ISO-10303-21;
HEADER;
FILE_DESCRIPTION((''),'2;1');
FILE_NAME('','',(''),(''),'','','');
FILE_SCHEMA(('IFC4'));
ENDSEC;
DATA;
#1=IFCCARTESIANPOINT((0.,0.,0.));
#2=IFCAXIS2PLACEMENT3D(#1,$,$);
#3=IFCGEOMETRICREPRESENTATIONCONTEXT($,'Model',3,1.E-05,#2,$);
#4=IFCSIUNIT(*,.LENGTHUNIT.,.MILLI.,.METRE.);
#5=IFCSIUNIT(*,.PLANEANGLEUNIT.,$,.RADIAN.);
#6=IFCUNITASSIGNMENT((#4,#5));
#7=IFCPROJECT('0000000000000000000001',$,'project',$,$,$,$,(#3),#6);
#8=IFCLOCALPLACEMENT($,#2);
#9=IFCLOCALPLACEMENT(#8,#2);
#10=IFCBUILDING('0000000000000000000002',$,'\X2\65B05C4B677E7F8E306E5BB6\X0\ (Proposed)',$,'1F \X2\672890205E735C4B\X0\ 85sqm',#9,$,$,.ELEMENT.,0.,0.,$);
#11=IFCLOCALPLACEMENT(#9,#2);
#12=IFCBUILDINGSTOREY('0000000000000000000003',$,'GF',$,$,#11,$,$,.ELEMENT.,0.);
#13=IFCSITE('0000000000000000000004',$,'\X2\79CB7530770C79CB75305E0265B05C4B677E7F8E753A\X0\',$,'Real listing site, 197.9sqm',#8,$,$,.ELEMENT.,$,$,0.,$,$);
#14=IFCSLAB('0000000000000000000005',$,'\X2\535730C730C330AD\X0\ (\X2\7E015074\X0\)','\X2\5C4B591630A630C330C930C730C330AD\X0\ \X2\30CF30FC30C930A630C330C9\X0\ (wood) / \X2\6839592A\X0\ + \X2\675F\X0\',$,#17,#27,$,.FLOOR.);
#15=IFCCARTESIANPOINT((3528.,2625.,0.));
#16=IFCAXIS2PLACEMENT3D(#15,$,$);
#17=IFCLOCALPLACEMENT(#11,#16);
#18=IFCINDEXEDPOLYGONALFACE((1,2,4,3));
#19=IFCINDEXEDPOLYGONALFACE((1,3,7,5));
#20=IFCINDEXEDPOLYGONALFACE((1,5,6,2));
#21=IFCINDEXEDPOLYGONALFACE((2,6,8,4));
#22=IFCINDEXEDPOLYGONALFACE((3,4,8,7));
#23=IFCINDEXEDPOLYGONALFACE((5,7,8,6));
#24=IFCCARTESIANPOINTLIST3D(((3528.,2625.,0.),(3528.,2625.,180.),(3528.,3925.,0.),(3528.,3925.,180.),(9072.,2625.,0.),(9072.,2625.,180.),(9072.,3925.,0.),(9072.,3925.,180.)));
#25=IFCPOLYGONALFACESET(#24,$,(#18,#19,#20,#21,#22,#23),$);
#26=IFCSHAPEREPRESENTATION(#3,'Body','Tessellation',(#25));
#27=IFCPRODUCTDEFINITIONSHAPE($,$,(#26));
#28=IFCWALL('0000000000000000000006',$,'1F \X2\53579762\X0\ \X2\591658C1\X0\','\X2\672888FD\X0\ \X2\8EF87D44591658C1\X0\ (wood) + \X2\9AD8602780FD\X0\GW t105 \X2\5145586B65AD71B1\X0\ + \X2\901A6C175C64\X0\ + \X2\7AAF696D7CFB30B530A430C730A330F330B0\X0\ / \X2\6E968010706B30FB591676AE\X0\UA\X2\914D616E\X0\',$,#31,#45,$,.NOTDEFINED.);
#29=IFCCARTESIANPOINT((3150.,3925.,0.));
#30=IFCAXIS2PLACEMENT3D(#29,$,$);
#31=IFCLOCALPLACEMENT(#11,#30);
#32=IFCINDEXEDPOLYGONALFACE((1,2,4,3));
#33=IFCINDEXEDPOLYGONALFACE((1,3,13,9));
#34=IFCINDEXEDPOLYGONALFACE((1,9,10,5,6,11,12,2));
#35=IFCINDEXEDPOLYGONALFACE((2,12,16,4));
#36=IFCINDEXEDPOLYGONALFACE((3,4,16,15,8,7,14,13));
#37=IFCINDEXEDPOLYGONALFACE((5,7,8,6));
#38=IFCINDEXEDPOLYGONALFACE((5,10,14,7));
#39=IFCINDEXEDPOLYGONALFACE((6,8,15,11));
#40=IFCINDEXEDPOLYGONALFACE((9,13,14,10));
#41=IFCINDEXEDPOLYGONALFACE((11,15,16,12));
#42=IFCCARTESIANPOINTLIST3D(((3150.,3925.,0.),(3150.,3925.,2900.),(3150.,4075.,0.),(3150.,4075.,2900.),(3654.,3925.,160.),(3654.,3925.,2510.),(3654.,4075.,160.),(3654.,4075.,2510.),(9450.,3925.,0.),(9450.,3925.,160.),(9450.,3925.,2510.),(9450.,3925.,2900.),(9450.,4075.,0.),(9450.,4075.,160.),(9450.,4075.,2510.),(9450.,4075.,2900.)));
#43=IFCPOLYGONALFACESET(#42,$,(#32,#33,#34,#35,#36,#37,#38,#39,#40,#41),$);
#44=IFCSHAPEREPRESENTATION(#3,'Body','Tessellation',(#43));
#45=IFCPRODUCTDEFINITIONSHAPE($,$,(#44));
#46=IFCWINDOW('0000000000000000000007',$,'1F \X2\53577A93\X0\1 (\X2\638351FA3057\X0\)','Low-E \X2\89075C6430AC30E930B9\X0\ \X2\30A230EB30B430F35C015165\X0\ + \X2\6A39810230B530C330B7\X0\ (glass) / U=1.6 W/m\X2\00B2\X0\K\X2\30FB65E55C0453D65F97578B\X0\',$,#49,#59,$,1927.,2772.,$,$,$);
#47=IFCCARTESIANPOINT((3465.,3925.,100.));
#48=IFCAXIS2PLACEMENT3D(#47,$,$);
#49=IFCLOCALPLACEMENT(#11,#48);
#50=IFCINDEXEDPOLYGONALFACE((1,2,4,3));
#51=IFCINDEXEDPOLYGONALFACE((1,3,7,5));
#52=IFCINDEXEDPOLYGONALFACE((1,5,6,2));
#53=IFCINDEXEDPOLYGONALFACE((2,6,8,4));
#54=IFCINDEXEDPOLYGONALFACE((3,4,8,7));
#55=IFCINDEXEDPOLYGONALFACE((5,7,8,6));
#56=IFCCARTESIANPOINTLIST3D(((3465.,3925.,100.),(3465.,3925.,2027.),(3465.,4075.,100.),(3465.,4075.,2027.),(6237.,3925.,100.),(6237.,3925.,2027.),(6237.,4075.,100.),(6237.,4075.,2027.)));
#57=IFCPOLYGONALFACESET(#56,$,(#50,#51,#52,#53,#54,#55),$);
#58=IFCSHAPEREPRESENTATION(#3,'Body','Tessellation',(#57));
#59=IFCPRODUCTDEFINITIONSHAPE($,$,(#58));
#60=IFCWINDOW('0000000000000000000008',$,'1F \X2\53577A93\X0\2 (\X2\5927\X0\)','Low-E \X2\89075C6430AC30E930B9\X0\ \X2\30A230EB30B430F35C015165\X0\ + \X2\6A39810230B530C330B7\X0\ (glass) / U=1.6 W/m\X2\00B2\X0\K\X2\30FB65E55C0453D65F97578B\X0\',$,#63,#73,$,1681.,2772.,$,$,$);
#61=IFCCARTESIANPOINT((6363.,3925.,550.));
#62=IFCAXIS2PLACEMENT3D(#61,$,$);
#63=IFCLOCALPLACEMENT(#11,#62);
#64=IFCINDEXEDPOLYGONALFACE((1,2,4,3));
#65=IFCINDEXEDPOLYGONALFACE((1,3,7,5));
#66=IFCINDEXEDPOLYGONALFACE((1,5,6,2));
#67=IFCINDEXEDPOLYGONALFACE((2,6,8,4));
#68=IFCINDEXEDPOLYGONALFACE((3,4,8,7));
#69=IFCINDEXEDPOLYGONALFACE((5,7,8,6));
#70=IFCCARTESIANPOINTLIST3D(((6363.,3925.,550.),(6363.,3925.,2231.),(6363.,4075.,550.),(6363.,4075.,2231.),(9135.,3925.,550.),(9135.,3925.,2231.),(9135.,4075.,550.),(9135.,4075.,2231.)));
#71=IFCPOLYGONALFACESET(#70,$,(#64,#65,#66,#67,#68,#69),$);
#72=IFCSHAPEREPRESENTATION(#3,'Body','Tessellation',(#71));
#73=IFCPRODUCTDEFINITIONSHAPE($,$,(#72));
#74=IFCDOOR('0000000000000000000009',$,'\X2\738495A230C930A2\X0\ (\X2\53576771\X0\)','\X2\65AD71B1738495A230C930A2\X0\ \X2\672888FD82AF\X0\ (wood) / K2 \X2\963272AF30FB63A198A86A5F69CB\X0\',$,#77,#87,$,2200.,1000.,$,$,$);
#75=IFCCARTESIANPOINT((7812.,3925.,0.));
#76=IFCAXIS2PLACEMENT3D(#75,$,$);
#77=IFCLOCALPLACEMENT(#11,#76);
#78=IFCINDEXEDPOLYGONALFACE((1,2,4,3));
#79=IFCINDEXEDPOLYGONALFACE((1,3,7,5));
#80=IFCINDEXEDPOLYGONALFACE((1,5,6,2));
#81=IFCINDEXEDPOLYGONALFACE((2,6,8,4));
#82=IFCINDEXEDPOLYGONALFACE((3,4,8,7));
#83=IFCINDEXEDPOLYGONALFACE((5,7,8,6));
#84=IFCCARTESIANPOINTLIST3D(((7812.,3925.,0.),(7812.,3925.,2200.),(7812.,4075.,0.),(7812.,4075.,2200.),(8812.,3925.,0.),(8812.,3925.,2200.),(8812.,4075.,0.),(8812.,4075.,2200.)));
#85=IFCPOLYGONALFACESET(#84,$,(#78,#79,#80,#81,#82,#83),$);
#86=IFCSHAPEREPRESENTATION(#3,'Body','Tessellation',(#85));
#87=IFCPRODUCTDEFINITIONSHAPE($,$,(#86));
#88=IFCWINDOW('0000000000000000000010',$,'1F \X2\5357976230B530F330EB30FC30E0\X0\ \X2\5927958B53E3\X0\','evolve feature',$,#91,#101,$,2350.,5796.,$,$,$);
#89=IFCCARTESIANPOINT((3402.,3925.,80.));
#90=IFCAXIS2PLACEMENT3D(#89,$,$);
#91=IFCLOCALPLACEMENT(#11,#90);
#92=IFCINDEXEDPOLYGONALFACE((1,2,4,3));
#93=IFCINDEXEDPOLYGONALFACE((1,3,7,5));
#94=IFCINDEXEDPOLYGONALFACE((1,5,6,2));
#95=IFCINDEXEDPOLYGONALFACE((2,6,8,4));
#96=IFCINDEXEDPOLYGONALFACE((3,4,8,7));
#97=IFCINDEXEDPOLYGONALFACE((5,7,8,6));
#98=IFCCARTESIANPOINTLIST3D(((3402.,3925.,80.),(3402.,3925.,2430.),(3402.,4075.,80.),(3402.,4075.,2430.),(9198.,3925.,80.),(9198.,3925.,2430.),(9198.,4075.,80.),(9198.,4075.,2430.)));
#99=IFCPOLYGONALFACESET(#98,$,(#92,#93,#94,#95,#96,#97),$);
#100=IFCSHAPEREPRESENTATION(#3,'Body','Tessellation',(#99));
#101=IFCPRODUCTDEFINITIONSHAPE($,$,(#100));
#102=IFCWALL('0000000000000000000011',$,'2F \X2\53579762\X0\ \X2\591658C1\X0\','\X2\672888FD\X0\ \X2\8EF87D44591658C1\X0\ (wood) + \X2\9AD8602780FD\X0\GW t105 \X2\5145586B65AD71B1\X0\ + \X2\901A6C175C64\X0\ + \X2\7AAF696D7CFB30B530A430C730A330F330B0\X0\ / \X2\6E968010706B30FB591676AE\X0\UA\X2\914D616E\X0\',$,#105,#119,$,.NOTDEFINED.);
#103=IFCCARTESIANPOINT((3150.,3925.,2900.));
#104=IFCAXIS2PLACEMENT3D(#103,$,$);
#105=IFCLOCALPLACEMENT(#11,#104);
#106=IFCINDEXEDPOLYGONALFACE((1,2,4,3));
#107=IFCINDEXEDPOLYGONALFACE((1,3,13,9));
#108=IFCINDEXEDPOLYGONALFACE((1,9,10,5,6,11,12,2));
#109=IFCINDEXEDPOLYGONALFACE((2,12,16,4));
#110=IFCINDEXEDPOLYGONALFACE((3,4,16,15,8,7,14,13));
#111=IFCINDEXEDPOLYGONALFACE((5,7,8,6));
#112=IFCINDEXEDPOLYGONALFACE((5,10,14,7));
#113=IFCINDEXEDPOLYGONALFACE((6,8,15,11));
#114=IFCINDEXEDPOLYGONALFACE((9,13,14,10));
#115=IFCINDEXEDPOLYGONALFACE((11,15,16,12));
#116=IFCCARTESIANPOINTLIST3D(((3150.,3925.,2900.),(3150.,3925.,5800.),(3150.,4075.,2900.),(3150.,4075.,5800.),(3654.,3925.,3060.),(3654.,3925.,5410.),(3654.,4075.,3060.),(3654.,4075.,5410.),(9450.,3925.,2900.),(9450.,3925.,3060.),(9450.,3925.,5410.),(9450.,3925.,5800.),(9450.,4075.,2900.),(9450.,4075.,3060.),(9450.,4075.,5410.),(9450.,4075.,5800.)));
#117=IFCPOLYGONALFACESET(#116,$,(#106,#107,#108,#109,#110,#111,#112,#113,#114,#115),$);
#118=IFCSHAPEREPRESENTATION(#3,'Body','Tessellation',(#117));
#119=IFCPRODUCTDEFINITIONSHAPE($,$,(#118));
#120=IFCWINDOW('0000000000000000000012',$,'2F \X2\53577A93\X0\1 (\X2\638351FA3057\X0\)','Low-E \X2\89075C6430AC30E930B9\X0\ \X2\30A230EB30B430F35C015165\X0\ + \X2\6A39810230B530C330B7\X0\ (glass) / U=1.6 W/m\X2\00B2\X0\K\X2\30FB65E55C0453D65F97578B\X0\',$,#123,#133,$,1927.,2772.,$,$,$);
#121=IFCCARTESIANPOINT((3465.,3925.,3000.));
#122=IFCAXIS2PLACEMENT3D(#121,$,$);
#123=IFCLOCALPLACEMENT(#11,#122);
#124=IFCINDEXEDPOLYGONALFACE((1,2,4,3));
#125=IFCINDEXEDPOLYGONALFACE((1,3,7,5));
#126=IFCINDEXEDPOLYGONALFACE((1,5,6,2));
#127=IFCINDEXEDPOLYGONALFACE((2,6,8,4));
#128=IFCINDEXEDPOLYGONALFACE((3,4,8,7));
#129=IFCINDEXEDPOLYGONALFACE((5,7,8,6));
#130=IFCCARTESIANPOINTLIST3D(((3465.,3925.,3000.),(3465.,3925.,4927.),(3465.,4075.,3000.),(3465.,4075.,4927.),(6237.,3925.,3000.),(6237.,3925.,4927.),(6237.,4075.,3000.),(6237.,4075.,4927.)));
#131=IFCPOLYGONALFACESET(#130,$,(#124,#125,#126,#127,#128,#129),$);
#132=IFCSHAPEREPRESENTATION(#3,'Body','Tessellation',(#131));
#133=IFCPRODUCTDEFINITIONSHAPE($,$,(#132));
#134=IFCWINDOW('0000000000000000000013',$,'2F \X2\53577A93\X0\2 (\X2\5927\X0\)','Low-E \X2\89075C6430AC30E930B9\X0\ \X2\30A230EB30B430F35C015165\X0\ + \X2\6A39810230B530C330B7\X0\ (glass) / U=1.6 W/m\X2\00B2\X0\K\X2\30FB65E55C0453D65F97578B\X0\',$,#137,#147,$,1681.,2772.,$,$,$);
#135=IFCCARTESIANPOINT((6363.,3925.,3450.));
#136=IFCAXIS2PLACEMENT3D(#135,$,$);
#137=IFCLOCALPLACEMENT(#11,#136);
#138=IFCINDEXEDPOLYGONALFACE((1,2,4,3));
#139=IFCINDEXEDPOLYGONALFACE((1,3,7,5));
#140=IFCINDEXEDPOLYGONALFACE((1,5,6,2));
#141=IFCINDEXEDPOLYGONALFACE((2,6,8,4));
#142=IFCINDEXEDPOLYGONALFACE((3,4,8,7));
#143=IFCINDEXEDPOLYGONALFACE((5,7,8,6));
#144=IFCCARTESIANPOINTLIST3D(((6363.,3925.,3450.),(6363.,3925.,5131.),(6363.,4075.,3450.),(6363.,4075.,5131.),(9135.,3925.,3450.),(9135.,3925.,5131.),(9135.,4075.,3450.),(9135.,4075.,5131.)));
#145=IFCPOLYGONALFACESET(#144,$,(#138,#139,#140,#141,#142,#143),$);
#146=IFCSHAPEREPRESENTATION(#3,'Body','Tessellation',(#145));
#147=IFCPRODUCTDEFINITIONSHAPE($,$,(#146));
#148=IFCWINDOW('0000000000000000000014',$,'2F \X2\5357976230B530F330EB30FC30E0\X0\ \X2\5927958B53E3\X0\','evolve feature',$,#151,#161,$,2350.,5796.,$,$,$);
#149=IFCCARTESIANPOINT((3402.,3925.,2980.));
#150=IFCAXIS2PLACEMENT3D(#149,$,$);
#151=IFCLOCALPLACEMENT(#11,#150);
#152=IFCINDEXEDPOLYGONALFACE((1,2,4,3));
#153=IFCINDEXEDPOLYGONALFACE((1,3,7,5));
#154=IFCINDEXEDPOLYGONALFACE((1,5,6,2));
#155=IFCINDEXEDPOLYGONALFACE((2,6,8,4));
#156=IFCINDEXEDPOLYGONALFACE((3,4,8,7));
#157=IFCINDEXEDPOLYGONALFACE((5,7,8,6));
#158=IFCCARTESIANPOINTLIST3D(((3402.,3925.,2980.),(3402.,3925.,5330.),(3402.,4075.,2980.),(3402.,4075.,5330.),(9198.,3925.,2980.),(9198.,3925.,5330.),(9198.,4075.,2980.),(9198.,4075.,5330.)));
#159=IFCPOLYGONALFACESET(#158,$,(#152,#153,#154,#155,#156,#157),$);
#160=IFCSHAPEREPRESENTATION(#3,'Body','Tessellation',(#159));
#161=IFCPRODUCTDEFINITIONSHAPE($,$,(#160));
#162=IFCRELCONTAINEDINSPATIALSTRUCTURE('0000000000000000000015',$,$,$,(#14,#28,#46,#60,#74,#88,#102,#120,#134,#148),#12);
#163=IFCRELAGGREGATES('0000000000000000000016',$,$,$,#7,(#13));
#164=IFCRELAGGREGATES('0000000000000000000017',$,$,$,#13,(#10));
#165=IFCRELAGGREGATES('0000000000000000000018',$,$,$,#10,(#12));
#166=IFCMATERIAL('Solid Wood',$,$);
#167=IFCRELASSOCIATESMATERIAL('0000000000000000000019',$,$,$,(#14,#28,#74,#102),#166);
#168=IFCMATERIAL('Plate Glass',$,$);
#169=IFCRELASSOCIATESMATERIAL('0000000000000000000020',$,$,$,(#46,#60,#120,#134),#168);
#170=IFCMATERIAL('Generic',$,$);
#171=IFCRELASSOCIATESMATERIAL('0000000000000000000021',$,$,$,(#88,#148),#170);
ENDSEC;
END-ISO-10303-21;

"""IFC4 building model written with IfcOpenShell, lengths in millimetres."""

from ifc_helpers import new_model, si_unit, frame, frame_2d, origin, place, context, project, spatial, rectangle, extrude, material, element, fill, save


model = new_model("IFC4")

# Units and contexts
model_context = context("Model", 3, precision=1e-05, world=origin())
ifc_project = project(units=[si_unit("LENGTHUNIT", "METRE", prefix="MILLI"), si_unit("PLANEANGLEUNIT", "RADIAN")], contexts=[model_context])

# Site, building, storey
site_placement = place(None, origin())
site = spatial("IfcSite", under=ifc_project, at=site_placement, Name="秋田県秋田市新屋松美町", ObjectType="Real listing site, 197.9sqm", CompositionType="ELEMENT", RefElevation=0.0)
building_placement = place(site_placement, origin())
building = spatial("IfcBuilding", under=site, at=building_placement, Name="新屋松美の家 (Proposed)", ObjectType="1F 木造平屋 85sqm", CompositionType="ELEMENT", ElevationOfRefHeight=0.0, ElevationOfTerrain=0.0)
storey_placement = place(building_placement, origin())
storey = spatial("IfcBuildingStorey", under=building, at=storey_placement, Name="GF", CompositionType="ELEMENT", Elevation=0.0)

# Slab
ifc_material_1 = material(Name="Solid Wood")
slab_1_placement = place(storey_placement, frame((3528.0, 2625.0, 0.0)))
element("IfcSlab", 1, at=slab_1_placement, inside=storey, material=ifc_material_1, Name="南デッキ (縁側)", Description="屋外ウッドデッキ ハードウッド (wood) / 根太 + 束", PredefinedType="FLOOR", context=model_context, shape_type="SweptSolid", body=[
    extrude(rectangle(XDim=5544.0, YDim=1300.0, at=frame_2d((2772.0, 650.0))), frame((3528.0, 2625.0, 0.0)), (0.0, 0.0, 1.0), 180.0),
])
ifc_material_2 = material(Name="Generic")

# Wall, openings, windows, door
wall_1_placement = place(storey_placement, frame((3150.0, 3925.0, 0.0)))
wall_1 = element("IfcWall", 2, at=wall_1_placement, inside=storey, material=ifc_material_1, Name="1F 南面 外壁", Description="木製 軸組外壁 (wood) + 高性能GW t105 充填断熱 + 通気層 + 窯業系サイディング / 準耐火・外皮UA配慮", PredefinedType="NOTDEFINED", context=model_context, shape_type="SweptSolid", body=[
    extrude(rectangle(XDim=6300.0, YDim=150.0, at=frame_2d((3150.0, 75.0))), frame((3150.0, 3925.0, 0.0)), (0.0, 0.0, 1.0), 2900.0),
])
opening_1_placement = place(storey_placement, frame((3465.0, 3925.0, 100.0)))
opening_1 = element("IfcOpeningElement", 3, at=opening_1_placement, cuts=wall_1, PredefinedType="NOTDEFINED", context=model_context, shape_type="SweptSolid", body=[
    extrude(rectangle(XDim=2772.0, YDim=150.0, at=frame_2d((1386.0, 75.0))), frame((3465.0, 3925.0, 100.0)), (0.0, 0.0, 1.0), 1927.0),
])
opening_2_placement = place(storey_placement, frame((6363.0, 3925.0, 550.0)))
opening_2 = element("IfcOpeningElement", 4, at=opening_2_placement, cuts=wall_1, PredefinedType="NOTDEFINED", context=model_context, shape_type="SweptSolid", body=[
    extrude(rectangle(XDim=2772.0, YDim=150.0, at=frame_2d((1386.0, 75.0))), frame((6363.0, 3925.0, 550.0)), (0.0, 0.0, 1.0), 1681.0),
])
opening_3_placement = place(storey_placement, frame((7812.0, 3925.0, 0.0)))
opening_3 = element("IfcOpeningElement", 5, at=opening_3_placement, cuts=wall_1, PredefinedType="NOTDEFINED", context=model_context, shape_type="SweptSolid", body=[
    extrude(rectangle(XDim=1000.0, YDim=150.0, at=frame_2d((500.0, 75.0))), frame((7812.0, 3925.0, 0.0)), (0.0, 0.0, 1.0), 2200.0),
])
opening_4_placement = place(storey_placement, frame((3402.0, 3925.0, 80.0)))
opening_4 = element("IfcOpeningElement", 6, at=opening_4_placement, cuts=wall_1, PredefinedType="NOTDEFINED", context=model_context, shape_type="SweptSolid", body=[
    extrude(rectangle(XDim=5796.0, YDim=150.0, at=frame_2d((2898.0, 75.0))), frame((3402.0, 3925.0, 80.0)), (0.0, 0.0, 1.0), 2350.0),
])
ifc_material_3 = material(Name="Plate Glass")
window_1_placement = place(storey_placement, frame((3465.0, 3925.0, 100.0)))
window_1 = element("IfcWindow", 7, at=window_1_placement, inside=storey, material=ifc_material_3, Name="1F 南窓1 (掃出し)", Description="Low-E 複層ガラス アルゴン封入 + 樹脂サッシ (glass) / U=1.6 W/m²K・日射取得型", OverallHeight=1927.0, OverallWidth=2772.0, context=model_context, shape_type="SweptSolid", body=[
    extrude(rectangle(XDim=2772.0, YDim=150.0, at=frame_2d((1386.0, 75.0))), frame((3465.0, 3925.0, 100.0)), (0.0, 0.0, 1.0), 1927.0),
])
fill(opening_1, window_1)
window_2_placement = place(storey_placement, frame((6363.0, 3925.0, 550.0)))
window_2 = element("IfcWindow", 8, at=window_2_placement, inside=storey, material=ifc_material_3, Name="1F 南窓2 (大)", Description="Low-E 複層ガラス アルゴン封入 + 樹脂サッシ (glass) / U=1.6 W/m²K・日射取得型", OverallHeight=1681.0, OverallWidth=2772.0, context=model_context, shape_type="SweptSolid", body=[
    extrude(rectangle(XDim=2772.0, YDim=150.0, at=frame_2d((1386.0, 75.0))), frame((6363.0, 3925.0, 550.0)), (0.0, 0.0, 1.0), 1681.0),
])
fill(opening_2, window_2)
door_placement = place(storey_placement, frame((7812.0, 3925.0, 0.0)))
door = element("IfcDoor", 9, at=door_placement, inside=storey, material=ifc_material_1, Name="玄関ドア (南東)", Description="断熱玄関ドア 木製芯 (wood) / K2 防犯・採風機構", OverallHeight=2200.0, OverallWidth=1000.0, context=model_context, shape_type="SweptSolid", body=[
    extrude(rectangle(XDim=1000.0, YDim=150.0, at=frame_2d((500.0, 75.0))), frame((7812.0, 3925.0, 0.0)), (0.0, 0.0, 1.0), 2200.0),
])
fill(opening_3, door)
window_3_placement = place(storey_placement, frame((3402.0, 3925.0, 80.0)))
window_3 = element("IfcWindow", 10, at=window_3_placement, inside=storey, material=ifc_material_2, Name="1F 南面サンルーム 大開口", Description="evolve feature", OverallHeight=2350.0, OverallWidth=5796.0, context=model_context, shape_type="SweptSolid", body=[
    extrude(rectangle(XDim=5796.0, YDim=150.0, at=frame_2d((2898.0, 75.0))), frame((3402.0, 3925.0, 80.0)), (0.0, 0.0, 1.0), 2350.0),
])
fill(opening_4, window_3)

# Wall, openings, windows
wall_2_placement = place(storey_placement, frame((3150.0, 3925.0, 2900.0)))
wall_2 = element("IfcWall", 11, at=wall_2_placement, inside=storey, material=ifc_material_1, Name="2F 南面 外壁", Description="木製 軸組外壁 (wood) + 高性能GW t105 充填断熱 + 通気層 + 窯業系サイディング / 準耐火・外皮UA配慮", PredefinedType="NOTDEFINED", context=model_context, shape_type="SweptSolid", body=[
    extrude(rectangle(XDim=6300.0, YDim=150.0, at=frame_2d((3150.0, 75.0))), frame((3150.0, 3925.0, 2900.0)), (0.0, 0.0, 1.0), 2900.0),
])
opening_5_placement = place(storey_placement, frame((3465.0, 3925.0, 3000.0)))
opening_5 = element("IfcOpeningElement", 12, at=opening_5_placement, cuts=wall_2, PredefinedType="NOTDEFINED", context=model_context, shape_type="SweptSolid", body=[
    extrude(rectangle(XDim=2772.0, YDim=150.0, at=frame_2d((1386.0, 75.0))), frame((3465.0, 3925.0, 3000.0)), (0.0, 0.0, 1.0), 1927.0),
])
opening_6_placement = place(storey_placement, frame((6363.0, 3925.0, 3450.0)))
opening_6 = element("IfcOpeningElement", 13, at=opening_6_placement, cuts=wall_2, PredefinedType="NOTDEFINED", context=model_context, shape_type="SweptSolid", body=[
    extrude(rectangle(XDim=2772.0, YDim=150.0, at=frame_2d((1386.0, 75.0))), frame((6363.0, 3925.0, 3450.0)), (0.0, 0.0, 1.0), 1681.0),
])
opening_7_placement = place(storey_placement, frame((3402.0, 3925.0, 2980.0)))
opening_7 = element("IfcOpeningElement", 14, at=opening_7_placement, cuts=wall_2, PredefinedType="NOTDEFINED", context=model_context, shape_type="SweptSolid", body=[
    extrude(rectangle(XDim=5796.0, YDim=150.0, at=frame_2d((2898.0, 75.0))), frame((3402.0, 3925.0, 2980.0)), (0.0, 0.0, 1.0), 2350.0),
])
window_4_placement = place(storey_placement, frame((3465.0, 3925.0, 3000.0)))
window_4 = element("IfcWindow", 15, at=window_4_placement, inside=storey, material=ifc_material_3, Name="2F 南窓1 (掃出し)", Description="Low-E 複層ガラス アルゴン封入 + 樹脂サッシ (glass) / U=1.6 W/m²K・日射取得型", OverallHeight=1927.0, OverallWidth=2772.0, context=model_context, shape_type="SweptSolid", body=[
    extrude(rectangle(XDim=2772.0, YDim=150.0, at=frame_2d((1386.0, 75.0))), frame((3465.0, 3925.0, 3000.0)), (0.0, 0.0, 1.0), 1927.0),
])
fill(opening_5, window_4)
window_5_placement = place(storey_placement, frame((6363.0, 3925.0, 3450.0)))
window_5 = element("IfcWindow", 16, at=window_5_placement, inside=storey, material=ifc_material_3, Name="2F 南窓2 (大)", Description="Low-E 複層ガラス アルゴン封入 + 樹脂サッシ (glass) / U=1.6 W/m²K・日射取得型", OverallHeight=1681.0, OverallWidth=2772.0, context=model_context, shape_type="SweptSolid", body=[
    extrude(rectangle(XDim=2772.0, YDim=150.0, at=frame_2d((1386.0, 75.0))), frame((6363.0, 3925.0, 3450.0)), (0.0, 0.0, 1.0), 1681.0),
])
fill(opening_6, window_5)
window_6_placement = place(storey_placement, frame((3402.0, 3925.0, 2980.0)))
window_6 = element("IfcWindow", 17, at=window_6_placement, inside=storey, material=ifc_material_2, Name="2F 南面サンルーム 大開口", Description="evolve feature", OverallHeight=2350.0, OverallWidth=5796.0, context=model_context, shape_type="SweptSolid", body=[
    extrude(rectangle(XDim=5796.0, YDim=150.0, at=frame_2d((2898.0, 75.0))), frame((3402.0, 3925.0, 2980.0)), (0.0, 0.0, 1.0), 2350.0),
])
fill(opening_7, window_6)

save(model, "model.ifc")
